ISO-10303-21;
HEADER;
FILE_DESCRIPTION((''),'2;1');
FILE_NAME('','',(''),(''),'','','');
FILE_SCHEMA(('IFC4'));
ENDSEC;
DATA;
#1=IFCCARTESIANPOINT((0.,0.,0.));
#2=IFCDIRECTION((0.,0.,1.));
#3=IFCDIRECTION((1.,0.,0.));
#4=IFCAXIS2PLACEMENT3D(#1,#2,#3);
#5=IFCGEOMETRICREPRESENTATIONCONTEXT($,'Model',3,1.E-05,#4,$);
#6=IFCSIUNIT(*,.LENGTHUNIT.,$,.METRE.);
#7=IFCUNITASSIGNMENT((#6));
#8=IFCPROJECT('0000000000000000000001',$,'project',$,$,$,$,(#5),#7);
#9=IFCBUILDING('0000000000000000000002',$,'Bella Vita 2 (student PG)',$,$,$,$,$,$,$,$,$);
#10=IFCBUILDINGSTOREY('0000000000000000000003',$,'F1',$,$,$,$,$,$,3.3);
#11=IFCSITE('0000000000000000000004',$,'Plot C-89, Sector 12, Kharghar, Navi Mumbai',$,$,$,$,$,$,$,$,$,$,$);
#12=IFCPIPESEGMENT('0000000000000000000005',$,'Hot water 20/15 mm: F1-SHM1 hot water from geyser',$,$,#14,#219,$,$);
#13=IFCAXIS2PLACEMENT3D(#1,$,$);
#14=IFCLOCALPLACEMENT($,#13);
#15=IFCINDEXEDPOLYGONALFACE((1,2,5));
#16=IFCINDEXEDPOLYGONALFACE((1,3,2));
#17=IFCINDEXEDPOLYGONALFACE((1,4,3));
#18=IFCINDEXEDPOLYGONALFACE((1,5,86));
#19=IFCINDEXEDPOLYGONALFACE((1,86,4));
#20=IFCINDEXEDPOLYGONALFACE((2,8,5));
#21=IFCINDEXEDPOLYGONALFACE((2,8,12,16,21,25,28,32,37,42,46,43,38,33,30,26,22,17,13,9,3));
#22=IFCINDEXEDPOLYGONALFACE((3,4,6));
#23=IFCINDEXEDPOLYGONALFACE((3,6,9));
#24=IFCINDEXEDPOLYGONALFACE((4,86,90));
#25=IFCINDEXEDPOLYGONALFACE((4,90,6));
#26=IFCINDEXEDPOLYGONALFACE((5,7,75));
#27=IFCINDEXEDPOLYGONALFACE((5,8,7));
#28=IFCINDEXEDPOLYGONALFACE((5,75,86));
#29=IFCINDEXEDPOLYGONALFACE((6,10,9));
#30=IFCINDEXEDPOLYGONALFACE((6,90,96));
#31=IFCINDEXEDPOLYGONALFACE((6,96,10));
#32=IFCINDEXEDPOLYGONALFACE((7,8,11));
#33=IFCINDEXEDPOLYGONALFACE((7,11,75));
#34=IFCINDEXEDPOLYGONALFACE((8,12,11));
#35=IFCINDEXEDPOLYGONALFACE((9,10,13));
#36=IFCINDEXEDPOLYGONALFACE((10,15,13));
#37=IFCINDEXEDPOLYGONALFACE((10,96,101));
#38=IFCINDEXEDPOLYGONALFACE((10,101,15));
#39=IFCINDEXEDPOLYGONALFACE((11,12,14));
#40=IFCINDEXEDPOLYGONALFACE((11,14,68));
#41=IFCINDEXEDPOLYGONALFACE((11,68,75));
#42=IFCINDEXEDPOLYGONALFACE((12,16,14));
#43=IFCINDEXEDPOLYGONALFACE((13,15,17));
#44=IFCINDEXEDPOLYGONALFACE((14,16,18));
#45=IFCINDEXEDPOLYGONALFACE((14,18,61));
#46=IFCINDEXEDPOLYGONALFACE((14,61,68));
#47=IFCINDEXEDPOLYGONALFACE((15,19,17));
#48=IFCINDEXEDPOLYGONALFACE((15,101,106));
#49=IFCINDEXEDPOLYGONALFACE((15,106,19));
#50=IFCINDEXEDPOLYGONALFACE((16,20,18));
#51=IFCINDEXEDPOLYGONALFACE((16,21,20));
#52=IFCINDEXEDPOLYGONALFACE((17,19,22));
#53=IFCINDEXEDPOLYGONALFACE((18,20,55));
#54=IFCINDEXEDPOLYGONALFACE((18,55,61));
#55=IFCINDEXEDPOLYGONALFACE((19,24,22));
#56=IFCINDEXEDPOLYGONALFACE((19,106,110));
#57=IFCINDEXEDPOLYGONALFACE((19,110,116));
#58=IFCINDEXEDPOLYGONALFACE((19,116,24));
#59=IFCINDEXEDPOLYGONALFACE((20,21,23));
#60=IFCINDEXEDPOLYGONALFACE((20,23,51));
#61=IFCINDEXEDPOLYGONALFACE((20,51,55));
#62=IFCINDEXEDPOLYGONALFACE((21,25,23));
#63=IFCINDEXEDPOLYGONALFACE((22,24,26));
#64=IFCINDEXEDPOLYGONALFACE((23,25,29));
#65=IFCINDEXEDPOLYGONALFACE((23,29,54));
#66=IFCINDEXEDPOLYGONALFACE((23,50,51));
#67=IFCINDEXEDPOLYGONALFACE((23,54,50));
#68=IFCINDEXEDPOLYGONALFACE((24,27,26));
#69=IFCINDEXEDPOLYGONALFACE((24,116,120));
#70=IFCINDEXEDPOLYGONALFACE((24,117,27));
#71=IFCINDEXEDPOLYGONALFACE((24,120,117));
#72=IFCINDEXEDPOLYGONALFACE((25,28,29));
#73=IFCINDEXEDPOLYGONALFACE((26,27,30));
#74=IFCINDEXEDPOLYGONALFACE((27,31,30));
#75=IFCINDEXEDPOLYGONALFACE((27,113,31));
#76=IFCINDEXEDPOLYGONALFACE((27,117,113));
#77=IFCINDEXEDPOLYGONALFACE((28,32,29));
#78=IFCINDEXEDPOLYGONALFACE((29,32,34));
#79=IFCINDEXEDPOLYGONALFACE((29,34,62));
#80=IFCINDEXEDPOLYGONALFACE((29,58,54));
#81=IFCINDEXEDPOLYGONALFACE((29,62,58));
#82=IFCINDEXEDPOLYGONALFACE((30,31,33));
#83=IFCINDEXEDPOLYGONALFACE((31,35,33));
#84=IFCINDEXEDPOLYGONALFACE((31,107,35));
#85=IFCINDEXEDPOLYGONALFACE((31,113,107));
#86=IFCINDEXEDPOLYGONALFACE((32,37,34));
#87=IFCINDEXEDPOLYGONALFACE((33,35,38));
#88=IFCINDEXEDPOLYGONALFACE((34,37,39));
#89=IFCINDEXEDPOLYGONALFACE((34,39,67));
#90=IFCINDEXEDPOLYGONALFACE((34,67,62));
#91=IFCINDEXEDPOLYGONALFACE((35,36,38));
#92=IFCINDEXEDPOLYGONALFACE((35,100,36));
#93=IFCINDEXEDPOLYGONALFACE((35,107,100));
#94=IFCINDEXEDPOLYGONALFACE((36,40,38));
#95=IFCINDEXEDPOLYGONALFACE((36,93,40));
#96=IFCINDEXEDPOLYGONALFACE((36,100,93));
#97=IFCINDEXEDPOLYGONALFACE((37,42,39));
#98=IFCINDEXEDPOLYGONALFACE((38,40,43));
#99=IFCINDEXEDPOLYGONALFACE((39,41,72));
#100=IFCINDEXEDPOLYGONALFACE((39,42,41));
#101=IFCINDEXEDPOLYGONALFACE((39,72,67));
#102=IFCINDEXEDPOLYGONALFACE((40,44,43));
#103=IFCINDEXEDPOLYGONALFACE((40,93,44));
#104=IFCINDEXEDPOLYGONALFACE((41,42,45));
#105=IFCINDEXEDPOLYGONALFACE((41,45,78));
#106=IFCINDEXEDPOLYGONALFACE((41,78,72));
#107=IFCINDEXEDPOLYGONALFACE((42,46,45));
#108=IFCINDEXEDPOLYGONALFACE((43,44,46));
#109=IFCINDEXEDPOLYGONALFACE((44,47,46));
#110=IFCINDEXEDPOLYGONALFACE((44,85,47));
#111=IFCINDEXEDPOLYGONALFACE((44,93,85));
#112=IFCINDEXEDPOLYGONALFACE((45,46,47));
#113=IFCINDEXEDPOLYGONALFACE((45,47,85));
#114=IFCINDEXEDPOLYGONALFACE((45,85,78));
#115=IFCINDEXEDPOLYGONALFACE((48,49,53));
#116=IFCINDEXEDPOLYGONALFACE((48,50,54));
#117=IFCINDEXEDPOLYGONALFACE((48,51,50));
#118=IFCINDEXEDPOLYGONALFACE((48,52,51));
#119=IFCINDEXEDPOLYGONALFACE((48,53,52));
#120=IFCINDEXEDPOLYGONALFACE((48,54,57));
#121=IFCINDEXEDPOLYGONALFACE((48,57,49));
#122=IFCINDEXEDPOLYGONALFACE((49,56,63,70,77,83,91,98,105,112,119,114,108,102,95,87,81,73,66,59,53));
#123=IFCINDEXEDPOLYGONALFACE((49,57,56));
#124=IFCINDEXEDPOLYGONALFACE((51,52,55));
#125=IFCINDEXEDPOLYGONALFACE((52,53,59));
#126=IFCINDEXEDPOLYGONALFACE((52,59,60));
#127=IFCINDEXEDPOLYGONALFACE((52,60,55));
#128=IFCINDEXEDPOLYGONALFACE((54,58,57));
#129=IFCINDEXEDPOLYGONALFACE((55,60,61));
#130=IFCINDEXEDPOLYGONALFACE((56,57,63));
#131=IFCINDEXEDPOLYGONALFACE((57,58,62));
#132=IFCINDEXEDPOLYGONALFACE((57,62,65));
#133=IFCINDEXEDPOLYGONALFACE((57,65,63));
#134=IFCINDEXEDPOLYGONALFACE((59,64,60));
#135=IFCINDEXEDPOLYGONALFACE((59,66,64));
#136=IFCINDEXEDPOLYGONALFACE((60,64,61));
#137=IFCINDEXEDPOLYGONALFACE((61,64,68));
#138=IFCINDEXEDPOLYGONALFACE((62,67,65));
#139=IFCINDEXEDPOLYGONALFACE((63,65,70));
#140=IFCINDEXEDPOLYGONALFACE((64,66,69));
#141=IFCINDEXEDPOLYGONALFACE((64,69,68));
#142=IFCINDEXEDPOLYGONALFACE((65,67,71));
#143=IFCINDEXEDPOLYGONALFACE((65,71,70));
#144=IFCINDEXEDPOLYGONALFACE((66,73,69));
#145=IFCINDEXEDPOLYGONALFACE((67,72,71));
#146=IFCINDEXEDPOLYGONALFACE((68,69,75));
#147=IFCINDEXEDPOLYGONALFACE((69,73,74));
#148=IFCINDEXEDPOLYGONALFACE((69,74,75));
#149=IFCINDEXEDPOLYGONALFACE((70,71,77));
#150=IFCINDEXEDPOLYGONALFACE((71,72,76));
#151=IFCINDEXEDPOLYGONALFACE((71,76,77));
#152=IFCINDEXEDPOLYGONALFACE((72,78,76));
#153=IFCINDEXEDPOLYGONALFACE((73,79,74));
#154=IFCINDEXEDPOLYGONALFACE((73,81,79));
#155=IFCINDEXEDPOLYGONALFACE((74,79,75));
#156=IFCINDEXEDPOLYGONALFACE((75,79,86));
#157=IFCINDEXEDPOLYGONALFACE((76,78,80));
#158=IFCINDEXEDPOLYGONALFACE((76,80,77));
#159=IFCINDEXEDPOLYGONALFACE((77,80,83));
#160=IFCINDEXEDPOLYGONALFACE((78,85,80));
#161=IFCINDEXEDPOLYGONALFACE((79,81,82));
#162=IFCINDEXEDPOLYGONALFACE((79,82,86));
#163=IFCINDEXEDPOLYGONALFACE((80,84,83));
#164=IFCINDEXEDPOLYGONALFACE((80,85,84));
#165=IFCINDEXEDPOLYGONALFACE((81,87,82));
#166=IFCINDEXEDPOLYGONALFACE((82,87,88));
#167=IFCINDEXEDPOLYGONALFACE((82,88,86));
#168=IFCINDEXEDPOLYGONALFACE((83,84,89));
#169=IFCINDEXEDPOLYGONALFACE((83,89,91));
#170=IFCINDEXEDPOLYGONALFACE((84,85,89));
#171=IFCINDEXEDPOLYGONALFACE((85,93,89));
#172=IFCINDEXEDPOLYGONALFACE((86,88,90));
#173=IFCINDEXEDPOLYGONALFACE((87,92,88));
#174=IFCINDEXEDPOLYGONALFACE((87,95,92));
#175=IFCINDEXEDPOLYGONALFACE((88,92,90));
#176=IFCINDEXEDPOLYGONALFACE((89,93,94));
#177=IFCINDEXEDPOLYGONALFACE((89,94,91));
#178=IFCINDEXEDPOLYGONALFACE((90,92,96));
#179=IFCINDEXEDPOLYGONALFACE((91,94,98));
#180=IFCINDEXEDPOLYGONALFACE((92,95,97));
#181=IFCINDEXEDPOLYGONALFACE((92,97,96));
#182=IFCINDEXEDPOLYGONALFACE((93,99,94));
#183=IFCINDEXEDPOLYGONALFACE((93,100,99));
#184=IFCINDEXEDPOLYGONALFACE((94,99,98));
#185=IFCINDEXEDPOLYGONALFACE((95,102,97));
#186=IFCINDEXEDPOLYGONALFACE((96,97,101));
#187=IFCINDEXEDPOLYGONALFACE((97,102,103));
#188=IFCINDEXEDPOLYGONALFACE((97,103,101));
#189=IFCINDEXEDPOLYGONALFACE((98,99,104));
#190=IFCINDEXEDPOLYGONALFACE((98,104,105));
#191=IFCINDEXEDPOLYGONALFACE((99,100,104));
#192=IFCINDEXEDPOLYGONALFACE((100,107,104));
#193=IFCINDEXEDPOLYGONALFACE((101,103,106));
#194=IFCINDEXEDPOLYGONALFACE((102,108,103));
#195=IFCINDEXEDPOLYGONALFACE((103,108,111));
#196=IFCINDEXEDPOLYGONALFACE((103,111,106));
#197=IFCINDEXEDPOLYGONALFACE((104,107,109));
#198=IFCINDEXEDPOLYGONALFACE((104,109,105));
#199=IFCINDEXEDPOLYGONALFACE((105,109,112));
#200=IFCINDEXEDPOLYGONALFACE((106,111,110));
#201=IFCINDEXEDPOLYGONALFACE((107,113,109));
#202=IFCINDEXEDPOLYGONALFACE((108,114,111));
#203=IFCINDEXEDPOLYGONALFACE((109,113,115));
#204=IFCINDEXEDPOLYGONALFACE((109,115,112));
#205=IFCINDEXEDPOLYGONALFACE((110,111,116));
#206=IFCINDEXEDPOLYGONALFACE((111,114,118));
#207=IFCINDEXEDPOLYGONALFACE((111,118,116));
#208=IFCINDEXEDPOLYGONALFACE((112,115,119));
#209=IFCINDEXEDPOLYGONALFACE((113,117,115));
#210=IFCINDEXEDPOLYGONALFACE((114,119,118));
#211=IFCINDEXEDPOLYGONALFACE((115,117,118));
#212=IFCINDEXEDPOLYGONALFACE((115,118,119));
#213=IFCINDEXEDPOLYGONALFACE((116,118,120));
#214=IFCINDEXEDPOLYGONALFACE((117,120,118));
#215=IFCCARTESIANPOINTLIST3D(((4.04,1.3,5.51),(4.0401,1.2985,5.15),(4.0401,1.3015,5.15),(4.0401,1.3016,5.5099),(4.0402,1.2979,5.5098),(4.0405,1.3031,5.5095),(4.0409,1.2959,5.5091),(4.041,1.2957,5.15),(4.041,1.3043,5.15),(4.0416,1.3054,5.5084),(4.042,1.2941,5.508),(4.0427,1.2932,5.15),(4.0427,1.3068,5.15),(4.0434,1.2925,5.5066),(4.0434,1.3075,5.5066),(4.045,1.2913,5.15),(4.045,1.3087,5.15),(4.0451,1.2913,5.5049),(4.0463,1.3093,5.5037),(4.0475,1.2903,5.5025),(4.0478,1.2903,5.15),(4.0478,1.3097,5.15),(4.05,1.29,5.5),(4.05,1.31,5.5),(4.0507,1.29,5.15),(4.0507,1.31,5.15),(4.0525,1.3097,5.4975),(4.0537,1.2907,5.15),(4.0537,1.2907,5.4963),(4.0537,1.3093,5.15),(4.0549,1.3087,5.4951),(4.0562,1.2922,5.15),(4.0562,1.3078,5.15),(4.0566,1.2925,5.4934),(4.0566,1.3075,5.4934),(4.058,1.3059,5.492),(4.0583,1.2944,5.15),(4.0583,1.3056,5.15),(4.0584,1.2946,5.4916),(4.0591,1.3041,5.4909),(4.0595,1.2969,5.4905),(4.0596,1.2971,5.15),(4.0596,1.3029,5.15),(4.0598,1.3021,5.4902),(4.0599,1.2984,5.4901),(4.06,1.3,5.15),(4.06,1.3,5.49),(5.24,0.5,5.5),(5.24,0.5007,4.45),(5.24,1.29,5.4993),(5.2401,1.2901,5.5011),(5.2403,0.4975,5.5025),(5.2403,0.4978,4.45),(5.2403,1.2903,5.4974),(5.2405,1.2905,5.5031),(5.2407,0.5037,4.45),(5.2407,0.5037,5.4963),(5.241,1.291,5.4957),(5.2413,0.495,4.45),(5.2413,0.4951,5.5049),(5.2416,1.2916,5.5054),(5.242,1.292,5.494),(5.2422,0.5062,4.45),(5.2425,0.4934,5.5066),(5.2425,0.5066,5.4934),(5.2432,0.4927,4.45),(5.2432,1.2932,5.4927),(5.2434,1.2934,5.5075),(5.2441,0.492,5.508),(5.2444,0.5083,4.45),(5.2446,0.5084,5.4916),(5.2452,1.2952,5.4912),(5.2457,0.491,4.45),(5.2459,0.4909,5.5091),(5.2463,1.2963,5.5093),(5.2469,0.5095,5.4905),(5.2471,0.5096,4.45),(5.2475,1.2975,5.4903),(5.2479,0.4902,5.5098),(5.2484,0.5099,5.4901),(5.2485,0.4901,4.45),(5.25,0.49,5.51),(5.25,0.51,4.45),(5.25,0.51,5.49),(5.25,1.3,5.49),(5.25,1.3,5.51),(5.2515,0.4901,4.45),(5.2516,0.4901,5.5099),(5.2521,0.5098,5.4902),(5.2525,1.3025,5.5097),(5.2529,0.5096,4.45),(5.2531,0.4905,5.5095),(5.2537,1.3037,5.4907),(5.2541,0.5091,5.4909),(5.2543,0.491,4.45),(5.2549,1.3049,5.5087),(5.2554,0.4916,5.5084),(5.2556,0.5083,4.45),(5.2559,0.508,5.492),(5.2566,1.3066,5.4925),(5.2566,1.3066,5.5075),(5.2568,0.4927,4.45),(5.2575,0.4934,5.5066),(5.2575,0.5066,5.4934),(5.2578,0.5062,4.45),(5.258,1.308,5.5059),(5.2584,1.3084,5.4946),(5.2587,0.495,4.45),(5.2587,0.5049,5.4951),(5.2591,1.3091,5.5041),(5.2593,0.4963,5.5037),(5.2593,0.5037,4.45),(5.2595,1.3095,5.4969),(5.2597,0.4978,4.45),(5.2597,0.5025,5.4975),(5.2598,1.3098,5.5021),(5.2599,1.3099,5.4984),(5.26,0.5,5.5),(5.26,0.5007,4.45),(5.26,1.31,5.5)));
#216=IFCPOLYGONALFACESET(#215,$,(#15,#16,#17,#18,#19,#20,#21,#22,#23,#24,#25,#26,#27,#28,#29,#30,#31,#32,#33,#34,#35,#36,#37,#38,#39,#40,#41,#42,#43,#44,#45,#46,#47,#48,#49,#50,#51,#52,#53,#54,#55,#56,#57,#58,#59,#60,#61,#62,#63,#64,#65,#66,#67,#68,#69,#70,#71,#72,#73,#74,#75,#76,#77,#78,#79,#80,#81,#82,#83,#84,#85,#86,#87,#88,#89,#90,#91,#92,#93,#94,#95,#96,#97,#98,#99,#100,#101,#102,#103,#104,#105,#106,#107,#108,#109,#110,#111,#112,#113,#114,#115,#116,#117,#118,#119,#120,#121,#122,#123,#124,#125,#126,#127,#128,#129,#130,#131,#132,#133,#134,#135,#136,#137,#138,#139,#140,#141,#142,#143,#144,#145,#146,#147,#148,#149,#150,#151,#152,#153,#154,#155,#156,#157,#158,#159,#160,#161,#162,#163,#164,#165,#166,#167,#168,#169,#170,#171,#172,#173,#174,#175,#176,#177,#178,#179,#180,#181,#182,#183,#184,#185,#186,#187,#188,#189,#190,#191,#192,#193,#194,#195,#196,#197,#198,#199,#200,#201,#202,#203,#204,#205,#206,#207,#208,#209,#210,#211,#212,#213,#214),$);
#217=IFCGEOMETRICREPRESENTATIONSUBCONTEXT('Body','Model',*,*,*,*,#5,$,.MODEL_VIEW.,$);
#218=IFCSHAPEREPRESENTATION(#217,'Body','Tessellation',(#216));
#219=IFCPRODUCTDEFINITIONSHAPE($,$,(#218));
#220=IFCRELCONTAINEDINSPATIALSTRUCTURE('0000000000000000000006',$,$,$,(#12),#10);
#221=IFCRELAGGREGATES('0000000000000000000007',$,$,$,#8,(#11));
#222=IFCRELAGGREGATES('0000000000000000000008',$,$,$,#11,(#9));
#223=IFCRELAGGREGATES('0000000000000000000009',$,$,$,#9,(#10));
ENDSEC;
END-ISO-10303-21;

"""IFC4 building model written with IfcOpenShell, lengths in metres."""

from ifc_helpers import new_model, entity, si_unit, origin, origin_with_axes, place, context, subcontext, project, spatial, element, save


model = new_model("IFC4")

# Units and contexts
model_context = context("Model", 3, precision=1e-05, world=origin_with_axes())
body_context = subcontext(model_context, "Body", "Model", "MODEL_VIEW")
ifc_project = project(units=[si_unit("LENGTHUNIT", "METRE")], contexts=[model_context])

# Site, building, storey
site = spatial("IfcSite", under=ifc_project, Name="Plot C-89, Sector 12, Kharghar, Navi Mumbai")
building = spatial("IfcBuilding", under=site, Name="Bella Vita 2 (student PG)")
storey = spatial("IfcBuildingStorey", under=building, Name="F1", Elevation=3.3)

# Pipe segment
pipe_segment_1_placement = place(None, origin())
element("IfcPipeSegment", 1, at=pipe_segment_1_placement, inside=storey, Name="Hot water 20/15 mm: F1-SHM1 hot water from geyser", context=body_context, shape_type="AdvancedSweptSolid", body=[
    entity("IfcSweptDiskSolid", entity("IfcPolyline", [entity("IfcCartesianPoint", [4.05, 1.3, 5.15]), entity("IfcCartesianPoint", [4.05, 1.3, 5.5]), entity("IfcCartesianPoint", [5.25, 1.3, 5.5]), entity("IfcCartesianPoint", [5.25, 0.5, 5.5]), entity("IfcCartesianPoint", [5.25, 0.5, 4.45])]), 0.01),
])

save(model, "model.ifc")
